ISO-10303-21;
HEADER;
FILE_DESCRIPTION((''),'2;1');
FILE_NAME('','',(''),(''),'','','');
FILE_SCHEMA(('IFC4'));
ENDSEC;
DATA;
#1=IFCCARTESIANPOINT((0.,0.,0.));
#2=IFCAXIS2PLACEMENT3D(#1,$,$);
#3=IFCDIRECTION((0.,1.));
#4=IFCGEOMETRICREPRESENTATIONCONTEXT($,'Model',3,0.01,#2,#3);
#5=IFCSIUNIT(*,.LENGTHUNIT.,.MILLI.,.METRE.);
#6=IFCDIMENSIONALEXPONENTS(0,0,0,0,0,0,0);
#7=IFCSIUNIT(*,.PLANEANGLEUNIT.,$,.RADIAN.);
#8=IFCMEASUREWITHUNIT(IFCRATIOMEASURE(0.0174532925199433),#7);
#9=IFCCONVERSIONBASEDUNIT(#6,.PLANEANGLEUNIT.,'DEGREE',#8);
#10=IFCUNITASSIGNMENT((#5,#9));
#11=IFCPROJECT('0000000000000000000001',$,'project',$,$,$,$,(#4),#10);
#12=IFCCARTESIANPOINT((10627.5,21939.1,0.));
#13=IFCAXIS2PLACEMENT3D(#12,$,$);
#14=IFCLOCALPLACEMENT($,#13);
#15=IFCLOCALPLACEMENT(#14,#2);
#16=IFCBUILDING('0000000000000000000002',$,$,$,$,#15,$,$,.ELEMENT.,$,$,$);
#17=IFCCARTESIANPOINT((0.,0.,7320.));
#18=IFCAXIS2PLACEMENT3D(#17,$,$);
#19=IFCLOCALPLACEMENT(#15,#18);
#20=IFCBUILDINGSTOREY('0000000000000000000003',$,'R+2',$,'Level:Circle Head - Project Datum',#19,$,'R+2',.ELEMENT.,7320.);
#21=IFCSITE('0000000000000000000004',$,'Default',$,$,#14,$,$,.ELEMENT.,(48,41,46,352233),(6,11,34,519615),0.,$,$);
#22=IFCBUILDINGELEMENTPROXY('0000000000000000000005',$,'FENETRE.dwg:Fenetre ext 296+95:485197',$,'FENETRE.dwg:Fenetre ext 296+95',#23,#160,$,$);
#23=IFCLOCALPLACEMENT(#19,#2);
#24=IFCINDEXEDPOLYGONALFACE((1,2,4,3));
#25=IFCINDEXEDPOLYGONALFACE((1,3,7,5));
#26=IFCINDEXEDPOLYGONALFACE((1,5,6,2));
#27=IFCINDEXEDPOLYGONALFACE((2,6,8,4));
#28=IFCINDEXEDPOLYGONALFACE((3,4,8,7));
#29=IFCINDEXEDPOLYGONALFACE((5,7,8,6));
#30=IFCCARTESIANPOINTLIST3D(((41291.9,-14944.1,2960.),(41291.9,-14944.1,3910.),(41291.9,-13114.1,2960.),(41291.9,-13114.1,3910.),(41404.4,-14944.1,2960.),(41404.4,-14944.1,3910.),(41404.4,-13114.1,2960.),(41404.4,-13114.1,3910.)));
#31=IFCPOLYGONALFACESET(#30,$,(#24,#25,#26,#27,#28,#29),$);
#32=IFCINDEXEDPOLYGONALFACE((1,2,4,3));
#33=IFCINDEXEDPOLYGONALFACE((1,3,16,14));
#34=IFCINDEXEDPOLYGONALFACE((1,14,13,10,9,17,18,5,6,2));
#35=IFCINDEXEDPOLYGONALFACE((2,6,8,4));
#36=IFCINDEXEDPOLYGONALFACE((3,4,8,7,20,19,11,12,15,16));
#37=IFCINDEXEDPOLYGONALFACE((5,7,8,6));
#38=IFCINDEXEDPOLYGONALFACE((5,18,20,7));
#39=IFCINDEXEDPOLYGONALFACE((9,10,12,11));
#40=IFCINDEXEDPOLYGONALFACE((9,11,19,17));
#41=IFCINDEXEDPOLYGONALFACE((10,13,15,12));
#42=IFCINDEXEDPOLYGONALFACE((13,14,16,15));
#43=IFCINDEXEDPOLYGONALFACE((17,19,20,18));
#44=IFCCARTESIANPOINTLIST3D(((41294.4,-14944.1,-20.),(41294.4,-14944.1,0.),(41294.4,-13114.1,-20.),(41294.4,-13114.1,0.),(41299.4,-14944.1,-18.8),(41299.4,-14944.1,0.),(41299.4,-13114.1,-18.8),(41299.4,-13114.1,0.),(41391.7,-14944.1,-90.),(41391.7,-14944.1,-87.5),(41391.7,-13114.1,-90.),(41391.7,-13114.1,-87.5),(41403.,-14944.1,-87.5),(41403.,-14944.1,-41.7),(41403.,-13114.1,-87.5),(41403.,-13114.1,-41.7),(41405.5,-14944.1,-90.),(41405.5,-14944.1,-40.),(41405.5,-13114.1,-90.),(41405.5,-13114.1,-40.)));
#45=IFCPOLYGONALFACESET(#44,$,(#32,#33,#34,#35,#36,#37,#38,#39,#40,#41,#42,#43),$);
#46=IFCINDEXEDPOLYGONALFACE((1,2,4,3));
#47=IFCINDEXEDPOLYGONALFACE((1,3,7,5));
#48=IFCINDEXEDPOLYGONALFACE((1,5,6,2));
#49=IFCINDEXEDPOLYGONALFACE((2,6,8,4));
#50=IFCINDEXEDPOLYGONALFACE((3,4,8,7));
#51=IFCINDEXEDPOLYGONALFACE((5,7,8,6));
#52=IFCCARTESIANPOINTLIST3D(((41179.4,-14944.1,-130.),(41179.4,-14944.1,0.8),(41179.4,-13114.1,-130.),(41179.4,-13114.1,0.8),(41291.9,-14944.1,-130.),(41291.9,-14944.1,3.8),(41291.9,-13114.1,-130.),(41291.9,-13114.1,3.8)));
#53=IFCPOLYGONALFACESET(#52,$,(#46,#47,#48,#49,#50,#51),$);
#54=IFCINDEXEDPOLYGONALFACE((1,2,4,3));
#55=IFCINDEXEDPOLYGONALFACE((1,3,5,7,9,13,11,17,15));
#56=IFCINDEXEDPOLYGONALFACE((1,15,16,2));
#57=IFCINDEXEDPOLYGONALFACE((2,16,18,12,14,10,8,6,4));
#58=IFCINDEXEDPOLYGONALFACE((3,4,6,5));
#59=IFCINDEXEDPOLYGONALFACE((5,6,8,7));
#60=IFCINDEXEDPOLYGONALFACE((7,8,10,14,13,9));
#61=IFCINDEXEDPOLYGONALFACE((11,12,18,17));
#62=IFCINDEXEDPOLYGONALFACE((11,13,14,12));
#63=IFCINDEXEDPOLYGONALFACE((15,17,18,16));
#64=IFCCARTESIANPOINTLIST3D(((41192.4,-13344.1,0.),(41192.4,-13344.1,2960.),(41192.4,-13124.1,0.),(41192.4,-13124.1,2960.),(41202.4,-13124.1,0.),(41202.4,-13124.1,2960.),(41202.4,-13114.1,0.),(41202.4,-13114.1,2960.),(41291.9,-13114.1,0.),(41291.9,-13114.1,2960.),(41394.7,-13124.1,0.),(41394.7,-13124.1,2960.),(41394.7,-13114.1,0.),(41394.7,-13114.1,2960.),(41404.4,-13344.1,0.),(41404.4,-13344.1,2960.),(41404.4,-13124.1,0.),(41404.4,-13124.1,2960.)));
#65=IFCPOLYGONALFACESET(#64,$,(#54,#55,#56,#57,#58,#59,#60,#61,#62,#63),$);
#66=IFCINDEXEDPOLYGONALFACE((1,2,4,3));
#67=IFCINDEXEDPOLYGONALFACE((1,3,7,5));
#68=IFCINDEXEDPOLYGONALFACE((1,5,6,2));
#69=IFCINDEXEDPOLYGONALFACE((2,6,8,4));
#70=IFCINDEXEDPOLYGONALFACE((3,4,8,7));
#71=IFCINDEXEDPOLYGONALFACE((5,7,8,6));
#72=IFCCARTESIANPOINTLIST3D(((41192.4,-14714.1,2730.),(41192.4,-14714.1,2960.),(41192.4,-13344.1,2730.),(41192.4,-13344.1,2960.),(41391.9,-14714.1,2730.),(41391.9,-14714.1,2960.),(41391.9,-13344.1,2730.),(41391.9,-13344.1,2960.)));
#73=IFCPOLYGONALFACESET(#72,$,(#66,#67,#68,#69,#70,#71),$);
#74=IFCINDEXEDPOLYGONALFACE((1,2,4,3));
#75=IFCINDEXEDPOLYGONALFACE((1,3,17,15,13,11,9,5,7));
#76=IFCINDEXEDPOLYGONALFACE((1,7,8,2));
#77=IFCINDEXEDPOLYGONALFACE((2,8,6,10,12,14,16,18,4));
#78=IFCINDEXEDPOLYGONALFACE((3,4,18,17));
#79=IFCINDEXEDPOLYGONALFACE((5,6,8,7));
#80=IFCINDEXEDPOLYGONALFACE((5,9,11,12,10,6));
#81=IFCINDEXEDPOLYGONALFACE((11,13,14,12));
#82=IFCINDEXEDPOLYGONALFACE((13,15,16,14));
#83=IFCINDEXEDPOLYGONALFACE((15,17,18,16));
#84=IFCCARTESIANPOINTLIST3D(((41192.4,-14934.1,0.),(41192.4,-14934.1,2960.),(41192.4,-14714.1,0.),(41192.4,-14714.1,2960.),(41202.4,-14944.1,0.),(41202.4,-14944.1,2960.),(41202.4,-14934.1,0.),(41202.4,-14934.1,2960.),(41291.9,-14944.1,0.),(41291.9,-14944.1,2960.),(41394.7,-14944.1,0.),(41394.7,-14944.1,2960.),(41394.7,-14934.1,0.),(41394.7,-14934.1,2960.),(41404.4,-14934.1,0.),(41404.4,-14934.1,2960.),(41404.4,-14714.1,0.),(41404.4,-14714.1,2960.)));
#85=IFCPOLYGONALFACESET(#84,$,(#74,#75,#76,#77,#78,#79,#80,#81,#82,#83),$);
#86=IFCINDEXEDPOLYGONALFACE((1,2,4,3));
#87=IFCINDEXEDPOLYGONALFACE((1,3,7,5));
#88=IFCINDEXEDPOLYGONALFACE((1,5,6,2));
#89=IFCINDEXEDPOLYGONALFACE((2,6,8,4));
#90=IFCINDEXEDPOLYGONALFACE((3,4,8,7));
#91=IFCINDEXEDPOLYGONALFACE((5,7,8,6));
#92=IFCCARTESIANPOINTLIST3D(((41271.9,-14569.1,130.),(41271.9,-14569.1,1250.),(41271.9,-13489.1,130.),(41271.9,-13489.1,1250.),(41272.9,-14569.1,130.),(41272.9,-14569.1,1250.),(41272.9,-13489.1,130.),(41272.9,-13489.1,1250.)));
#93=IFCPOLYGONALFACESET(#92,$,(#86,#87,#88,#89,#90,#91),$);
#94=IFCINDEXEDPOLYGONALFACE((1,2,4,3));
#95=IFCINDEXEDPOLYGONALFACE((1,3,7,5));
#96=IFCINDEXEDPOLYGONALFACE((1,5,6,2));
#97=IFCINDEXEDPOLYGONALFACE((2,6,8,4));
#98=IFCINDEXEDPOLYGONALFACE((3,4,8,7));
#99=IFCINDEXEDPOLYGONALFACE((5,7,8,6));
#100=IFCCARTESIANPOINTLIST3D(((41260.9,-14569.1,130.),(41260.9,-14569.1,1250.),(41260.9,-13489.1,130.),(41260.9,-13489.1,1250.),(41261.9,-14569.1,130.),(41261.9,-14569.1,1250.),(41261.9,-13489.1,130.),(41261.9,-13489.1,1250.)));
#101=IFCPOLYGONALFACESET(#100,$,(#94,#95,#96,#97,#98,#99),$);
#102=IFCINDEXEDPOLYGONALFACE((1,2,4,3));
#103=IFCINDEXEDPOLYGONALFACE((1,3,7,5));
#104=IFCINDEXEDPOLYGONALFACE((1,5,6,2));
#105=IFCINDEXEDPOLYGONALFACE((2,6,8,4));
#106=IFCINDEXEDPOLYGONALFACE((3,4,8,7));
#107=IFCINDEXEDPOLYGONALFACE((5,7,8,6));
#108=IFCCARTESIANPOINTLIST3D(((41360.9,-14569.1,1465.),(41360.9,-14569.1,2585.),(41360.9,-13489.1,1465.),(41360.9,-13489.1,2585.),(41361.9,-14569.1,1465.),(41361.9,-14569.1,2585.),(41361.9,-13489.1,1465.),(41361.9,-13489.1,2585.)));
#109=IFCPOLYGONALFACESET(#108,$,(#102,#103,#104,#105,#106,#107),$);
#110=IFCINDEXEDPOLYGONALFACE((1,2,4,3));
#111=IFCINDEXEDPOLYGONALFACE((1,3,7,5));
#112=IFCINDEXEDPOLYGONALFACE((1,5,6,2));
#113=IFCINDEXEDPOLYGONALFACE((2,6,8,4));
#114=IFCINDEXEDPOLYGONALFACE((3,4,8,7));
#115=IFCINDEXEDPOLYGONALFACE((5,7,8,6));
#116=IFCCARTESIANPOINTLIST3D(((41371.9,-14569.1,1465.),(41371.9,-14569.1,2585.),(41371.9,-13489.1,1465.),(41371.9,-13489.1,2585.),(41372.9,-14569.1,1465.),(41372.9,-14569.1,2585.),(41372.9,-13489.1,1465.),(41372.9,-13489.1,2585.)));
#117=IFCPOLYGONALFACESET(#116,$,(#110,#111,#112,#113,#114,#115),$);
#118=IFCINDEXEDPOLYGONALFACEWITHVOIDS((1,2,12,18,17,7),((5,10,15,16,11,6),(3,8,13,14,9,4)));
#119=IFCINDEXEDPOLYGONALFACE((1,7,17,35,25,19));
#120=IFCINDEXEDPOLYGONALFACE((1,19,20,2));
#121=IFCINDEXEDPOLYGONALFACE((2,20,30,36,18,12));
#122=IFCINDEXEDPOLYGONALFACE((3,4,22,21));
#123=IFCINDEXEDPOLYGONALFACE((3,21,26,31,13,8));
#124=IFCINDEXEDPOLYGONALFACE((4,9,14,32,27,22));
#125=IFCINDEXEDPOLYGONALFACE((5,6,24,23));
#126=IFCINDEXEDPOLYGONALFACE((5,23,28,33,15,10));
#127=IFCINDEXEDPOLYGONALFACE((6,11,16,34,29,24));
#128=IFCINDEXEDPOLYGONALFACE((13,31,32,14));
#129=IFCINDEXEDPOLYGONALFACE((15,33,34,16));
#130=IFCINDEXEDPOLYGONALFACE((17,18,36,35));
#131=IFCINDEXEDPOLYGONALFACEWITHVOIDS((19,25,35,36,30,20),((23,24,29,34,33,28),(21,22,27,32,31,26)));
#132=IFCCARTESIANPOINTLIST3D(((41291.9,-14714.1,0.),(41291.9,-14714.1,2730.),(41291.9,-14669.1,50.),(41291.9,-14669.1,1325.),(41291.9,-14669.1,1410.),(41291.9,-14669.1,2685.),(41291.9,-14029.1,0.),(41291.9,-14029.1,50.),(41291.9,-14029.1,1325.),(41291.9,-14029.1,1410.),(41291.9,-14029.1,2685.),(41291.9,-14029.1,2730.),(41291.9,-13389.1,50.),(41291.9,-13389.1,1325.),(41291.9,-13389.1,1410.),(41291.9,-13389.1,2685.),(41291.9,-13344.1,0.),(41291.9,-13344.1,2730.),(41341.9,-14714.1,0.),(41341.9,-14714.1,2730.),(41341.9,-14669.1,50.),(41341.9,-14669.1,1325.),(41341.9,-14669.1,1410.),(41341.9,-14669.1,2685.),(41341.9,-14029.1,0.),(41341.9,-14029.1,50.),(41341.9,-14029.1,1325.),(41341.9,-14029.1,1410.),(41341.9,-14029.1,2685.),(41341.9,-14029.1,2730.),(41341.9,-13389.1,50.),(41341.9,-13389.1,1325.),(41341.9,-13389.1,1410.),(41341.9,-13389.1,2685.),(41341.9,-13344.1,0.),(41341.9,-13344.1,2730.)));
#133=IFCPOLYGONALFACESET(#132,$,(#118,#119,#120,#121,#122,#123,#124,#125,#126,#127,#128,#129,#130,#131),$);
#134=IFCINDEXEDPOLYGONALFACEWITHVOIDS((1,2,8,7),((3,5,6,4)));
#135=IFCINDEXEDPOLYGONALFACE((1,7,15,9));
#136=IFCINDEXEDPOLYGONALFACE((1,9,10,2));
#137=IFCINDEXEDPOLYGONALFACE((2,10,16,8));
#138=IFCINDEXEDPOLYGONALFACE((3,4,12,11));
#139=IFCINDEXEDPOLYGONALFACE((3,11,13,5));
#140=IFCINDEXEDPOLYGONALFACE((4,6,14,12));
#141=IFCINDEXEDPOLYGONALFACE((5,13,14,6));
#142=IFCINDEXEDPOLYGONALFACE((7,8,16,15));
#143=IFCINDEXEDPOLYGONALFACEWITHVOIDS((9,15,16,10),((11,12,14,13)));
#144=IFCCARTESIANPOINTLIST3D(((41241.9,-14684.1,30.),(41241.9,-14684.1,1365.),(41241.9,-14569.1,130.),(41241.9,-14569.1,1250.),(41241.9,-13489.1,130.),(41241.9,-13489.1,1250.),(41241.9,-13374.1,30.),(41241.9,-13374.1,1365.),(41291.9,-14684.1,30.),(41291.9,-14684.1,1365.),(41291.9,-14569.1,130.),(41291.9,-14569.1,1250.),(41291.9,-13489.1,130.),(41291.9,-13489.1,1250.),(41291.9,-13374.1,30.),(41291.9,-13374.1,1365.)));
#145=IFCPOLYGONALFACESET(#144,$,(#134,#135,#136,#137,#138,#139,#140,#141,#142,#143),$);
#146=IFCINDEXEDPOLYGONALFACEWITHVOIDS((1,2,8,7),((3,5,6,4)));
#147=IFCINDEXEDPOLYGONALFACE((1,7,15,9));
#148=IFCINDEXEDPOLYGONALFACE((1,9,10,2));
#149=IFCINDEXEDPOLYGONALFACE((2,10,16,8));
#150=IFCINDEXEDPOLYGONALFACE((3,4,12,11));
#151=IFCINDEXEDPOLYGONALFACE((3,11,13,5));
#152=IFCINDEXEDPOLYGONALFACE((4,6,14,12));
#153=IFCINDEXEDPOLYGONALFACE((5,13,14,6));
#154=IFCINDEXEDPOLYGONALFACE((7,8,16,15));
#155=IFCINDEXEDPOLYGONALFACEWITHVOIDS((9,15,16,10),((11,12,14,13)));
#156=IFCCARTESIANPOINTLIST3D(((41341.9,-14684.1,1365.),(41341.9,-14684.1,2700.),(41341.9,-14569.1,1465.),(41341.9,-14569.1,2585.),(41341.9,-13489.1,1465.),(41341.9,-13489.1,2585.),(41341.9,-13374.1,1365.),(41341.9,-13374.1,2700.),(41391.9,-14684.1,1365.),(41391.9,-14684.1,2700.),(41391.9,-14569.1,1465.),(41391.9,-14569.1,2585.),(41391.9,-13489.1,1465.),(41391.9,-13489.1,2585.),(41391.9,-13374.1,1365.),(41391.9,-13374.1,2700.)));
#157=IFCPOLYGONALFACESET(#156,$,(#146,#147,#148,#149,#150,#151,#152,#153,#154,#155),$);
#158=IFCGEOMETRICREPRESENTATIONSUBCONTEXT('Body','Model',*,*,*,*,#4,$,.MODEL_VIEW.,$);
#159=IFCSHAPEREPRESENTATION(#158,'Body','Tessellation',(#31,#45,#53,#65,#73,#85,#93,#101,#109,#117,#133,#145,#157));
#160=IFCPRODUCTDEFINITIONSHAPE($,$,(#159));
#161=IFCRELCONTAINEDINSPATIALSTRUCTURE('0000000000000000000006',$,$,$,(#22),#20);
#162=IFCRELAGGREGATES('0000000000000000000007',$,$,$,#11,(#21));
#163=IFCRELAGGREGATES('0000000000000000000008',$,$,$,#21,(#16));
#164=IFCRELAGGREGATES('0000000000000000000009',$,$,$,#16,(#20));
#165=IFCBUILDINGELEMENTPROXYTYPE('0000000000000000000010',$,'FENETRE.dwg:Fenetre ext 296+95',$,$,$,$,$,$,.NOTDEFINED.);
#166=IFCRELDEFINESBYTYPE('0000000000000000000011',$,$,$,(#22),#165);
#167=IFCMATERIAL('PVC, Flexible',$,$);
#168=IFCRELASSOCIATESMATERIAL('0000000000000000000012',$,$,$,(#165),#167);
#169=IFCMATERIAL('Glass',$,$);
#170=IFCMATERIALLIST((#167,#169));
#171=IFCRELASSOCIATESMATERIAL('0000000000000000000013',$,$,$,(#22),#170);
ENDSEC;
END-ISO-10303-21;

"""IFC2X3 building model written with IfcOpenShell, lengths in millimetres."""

from ifc_helpers import new_model, entity, si_unit, converted_unit, direction, frame, frame_2d, origin, origin_2d_with_axis, place, context, subcontext, project, spatial, polyline, rectangle, outline, extrude, source, transform, mapped, material, material_list, type_object, type_shapes, element, save


model = new_model("IFC2X3")

# Units and contexts
model_context = context("Model", 3, precision=0.01, world=origin(), true_north=direction((0.0, 1.0)))
body_context = subcontext(model_context, "Body", "Model", "MODEL_VIEW")
ifc_project = project(units=[si_unit("LENGTHUNIT", "METRE", prefix="MILLI"), converted_unit("PLANEANGLEUNIT", "DEGREE", entity("IfcRatioMeasure", 0.0174532925199433), si_unit("PLANEANGLEUNIT", "RADIAN"), dimensions=[0, 0, 0, 0, 0, 0, 0])], contexts=[model_context])

# Site, building, storey
site_placement = place(None, frame((10627.5, 21939.1, 0.0)))
site = spatial("IfcSite", under=ifc_project, at=site_placement, Name="Default", CompositionType="ELEMENT", RefLatitude=(48, 41, 46, 352233), RefLongitude=(6, 11, 34, 519615), RefElevation=0.0)
building_placement = place(site_placement, origin())
building = spatial("IfcBuilding", under=site, at=building_placement, CompositionType="ELEMENT")
storey_placement = place(building_placement, frame((0.0, 0.0, 7320.0)))
storey = spatial("IfcBuildingStorey", under=building, at=storey_placement, Name="R+2", ObjectType="Level:Circle Head - Project Datum", LongName="R+2", CompositionType="ELEMENT", Elevation=7320.0)

# Building element proxy
ifc_material_1 = material(Name="PVC, Flexible")
ifc_material_2 = material(Name="Glass")
building_element_proxy_type_1 = type_object("IfcBuildingElementProxyType", Name="FENETRE.dwg:Fenetre ext 296+95", PredefinedType="NOTDEFINED", material=ifc_material_1)
shared_shape_1 = source(origin(), body_context, "Body", "SweptSolid", [
    extrude(rectangle(XDim=112.5, YDim=1830.0, at=origin_2d_with_axis()), frame((-10.4, -56.3, 2960.0), z_axis=(0.0, 0.0, 1.0), x_axis=(0.0, 1.0, 0.0)), (0.0, 0.0, 1.0), 950.0),
    extrude(outline(polyline([(27.5, -64.4), (47.5, -64.4), (47.5, -59.4), (28.8, -59.4), (7.5, 46.7), (-42.5, 46.7), (-42.5, 32.9), (-40.0, 32.9), (-40.0, 44.2), (5.8, 44.2), (27.5, -64.4)])), frame((-925.4, -66.9, -47.5), z_axis=(1.0, 0.0, 0.0), x_axis=(0.0, 0.0, 1.0)), (0.0, 0.0, 1.0), 1830.0),
    extrude(outline(polyline([(-54.5, -66.1), (58.0, -66.1), (54.5, 67.6), (-58.0, 64.6), (-54.5, -66.1)])), frame((-925.4, 56.3, -63.8), z_axis=(1.0, 0.0, 0.0), x_axis=(0.0, -0.999645, 0.02665)), (0.0, 0.0, 1.0), 1830.0),
    extrude(outline(polyline([(-97.0, -55.6), (5.9, -55.6), (95.4, -55.6), (95.4, -45.6), (105.4, -45.6), (105.4, 174.4), (-106.6, 174.4), (-106.6, -45.6), (-97.0, -45.6), (-97.0, -55.6)])), frame((849.0, -5.9, 0.0), z_axis=(0.0, 0.0, 1.0), x_axis=(0.0, 1.0, 0.0)), (0.0, 0.0, 1.0), 2960.0),
    extrude(rectangle(XDim=1370.0, YDim=199.5, at=origin_2d_with_axis()), frame((-10.4, -0.3, 2730.0), z_axis=(0.0, 0.0, 1.0), x_axis=(-1.0, 0.0, 0.0)), (0.0, 0.0, 1.0), 230.0),
    extrude(outline(polyline([(-55.6, 97.0), (-55.6, -5.9), (-55.6, -95.4), (-45.6, -95.4), (-45.6, -105.4), (174.4, -105.4), (174.4, 106.6), (-45.6, 106.6), (-45.6, 97.0), (-55.6, 97.0)])), frame((-869.9, -5.9, 0.0), z_axis=(0.0, 0.0, -1.0), x_axis=(1.0, 0.0, 0.0)), (0.0, 0.0, -1.0), 2960.0),
    extrude(rectangle(XDim=1080.0, YDim=1.0, at=origin_2d_with_axis()), frame((-10.4, 19.5, 130.0), z_axis=(0.0, 0.0, 1.0), x_axis=(-1.0, 0.0, 0.0)), (0.0, 0.0, 1.0), 1120.0),
    extrude(rectangle(XDim=1080.0, YDim=1.0, at=origin_2d_with_axis()), frame((-10.4, 30.5, 130.0), z_axis=(0.0, 0.0, 1.0), x_axis=(-1.0, 0.0, 0.0)), (0.0, 0.0, 1.0), 1120.0),
    extrude(rectangle(XDim=1080.0, YDim=1.0, at=frame_2d((0.0, 0.0), x_axis=(1.0, 0.0))), frame((-10.4, -69.5, 1465.0), z_axis=(0.0, 0.0, 1.0), x_axis=(-1.0, 0.0, 0.0)), (0.0, 0.0, 1.0), 1120.0),
    extrude(rectangle(XDim=1080.0, YDim=1.0, at=frame_2d((0.0, 0.0), x_axis=(1.0, 0.0))), frame((-10.4, -80.5, 1465.0), z_axis=(0.0, 0.0, 1.0), x_axis=(-1.0, 0.0, 0.0)), (0.0, 0.0, 1.0), 1120.0),
    extrude(outline(polyline([(-685.0, -1365.0), (0.0, -1365.0), (685.0, -1365.0), (685.0, 1365.0), (0.0, 1365.0), (-685.0, 1365.0), (-685.0, -1365.0)]), holes=[polyline([(-640.0, -1320.0), (-640.0, -45.0), (0.0, -45.0), (640.0, -45.0), (640.0, -1320.0), (0.0, -1320.0), (-640.0, -1320.0)]), polyline([(-640.0, 40.0), (-640.0, 1315.0), (0.0, 1315.0), (640.0, 1315.0), (640.0, 40.0), (0.0, 40.0), (-640.0, 40.0)])]), frame((-10.4, -50.0, 1365.0), z_axis=(0.0, 1.0, 0.0), x_axis=(1.0, 0.0, 0.0)), (0.0, 0.0, 1.0), 50.0),
    extrude(outline(polyline([(-655.0, -667.5), (655.0, -667.5), (655.0, 667.5), (-655.0, 667.5), (-655.0, -667.5)]), holes=[polyline([(-540.0, 552.5), (540.0, 552.5), (540.0, -567.5), (-540.0, -567.5), (-540.0, 552.5)])]), frame((-10.4, 0.0, 697.5), z_axis=(0.0, 1.0, 0.0), x_axis=(-1.0, 0.0, 0.0)), (0.0, 0.0, 1.0), 50.0),
    extrude(outline(polyline([(-655.0, -667.5), (655.0, -667.5), (655.0, 667.5), (-655.0, 667.5), (-655.0, -667.5)]), holes=[polyline([(-540.0, 552.5), (540.0, 552.5), (540.0, -567.5), (-540.0, -567.5), (-540.0, 552.5)])]), frame((-10.4, -100.0, 2032.5), z_axis=(0.0, 1.0, 0.0), x_axis=(-1.0, 0.0, 0.0)), (0.0, 0.0, 1.0), 50.0),
])
type_shapes(building_element_proxy_type_1, [shared_shape_1])
ifc_material_list_1 = material_list([ifc_material_1, ifc_material_2])
proxy_1_placement = place(storey_placement, frame((41291.9, -14018.7, 0.0), z_axis=(0.0, 0.0, 1.0), x_axis=(0.0, 1.0, 0.0)))
element("IfcBuildingElementProxy", 1, at=proxy_1_placement, inside=storey, type_object=building_element_proxy_type_1, material=ifc_material_list_1, Name="FENETRE.dwg:Fenetre ext 296+95:485197", ObjectType="FENETRE.dwg:Fenetre ext 296+95", context=body_context, shape_type="MappedRepresentation", body=[
    mapped(shared_shape_1, transform((0.0, 0.0, 0.0), scale=1.0)),
])

save(model, "model.ifc")
